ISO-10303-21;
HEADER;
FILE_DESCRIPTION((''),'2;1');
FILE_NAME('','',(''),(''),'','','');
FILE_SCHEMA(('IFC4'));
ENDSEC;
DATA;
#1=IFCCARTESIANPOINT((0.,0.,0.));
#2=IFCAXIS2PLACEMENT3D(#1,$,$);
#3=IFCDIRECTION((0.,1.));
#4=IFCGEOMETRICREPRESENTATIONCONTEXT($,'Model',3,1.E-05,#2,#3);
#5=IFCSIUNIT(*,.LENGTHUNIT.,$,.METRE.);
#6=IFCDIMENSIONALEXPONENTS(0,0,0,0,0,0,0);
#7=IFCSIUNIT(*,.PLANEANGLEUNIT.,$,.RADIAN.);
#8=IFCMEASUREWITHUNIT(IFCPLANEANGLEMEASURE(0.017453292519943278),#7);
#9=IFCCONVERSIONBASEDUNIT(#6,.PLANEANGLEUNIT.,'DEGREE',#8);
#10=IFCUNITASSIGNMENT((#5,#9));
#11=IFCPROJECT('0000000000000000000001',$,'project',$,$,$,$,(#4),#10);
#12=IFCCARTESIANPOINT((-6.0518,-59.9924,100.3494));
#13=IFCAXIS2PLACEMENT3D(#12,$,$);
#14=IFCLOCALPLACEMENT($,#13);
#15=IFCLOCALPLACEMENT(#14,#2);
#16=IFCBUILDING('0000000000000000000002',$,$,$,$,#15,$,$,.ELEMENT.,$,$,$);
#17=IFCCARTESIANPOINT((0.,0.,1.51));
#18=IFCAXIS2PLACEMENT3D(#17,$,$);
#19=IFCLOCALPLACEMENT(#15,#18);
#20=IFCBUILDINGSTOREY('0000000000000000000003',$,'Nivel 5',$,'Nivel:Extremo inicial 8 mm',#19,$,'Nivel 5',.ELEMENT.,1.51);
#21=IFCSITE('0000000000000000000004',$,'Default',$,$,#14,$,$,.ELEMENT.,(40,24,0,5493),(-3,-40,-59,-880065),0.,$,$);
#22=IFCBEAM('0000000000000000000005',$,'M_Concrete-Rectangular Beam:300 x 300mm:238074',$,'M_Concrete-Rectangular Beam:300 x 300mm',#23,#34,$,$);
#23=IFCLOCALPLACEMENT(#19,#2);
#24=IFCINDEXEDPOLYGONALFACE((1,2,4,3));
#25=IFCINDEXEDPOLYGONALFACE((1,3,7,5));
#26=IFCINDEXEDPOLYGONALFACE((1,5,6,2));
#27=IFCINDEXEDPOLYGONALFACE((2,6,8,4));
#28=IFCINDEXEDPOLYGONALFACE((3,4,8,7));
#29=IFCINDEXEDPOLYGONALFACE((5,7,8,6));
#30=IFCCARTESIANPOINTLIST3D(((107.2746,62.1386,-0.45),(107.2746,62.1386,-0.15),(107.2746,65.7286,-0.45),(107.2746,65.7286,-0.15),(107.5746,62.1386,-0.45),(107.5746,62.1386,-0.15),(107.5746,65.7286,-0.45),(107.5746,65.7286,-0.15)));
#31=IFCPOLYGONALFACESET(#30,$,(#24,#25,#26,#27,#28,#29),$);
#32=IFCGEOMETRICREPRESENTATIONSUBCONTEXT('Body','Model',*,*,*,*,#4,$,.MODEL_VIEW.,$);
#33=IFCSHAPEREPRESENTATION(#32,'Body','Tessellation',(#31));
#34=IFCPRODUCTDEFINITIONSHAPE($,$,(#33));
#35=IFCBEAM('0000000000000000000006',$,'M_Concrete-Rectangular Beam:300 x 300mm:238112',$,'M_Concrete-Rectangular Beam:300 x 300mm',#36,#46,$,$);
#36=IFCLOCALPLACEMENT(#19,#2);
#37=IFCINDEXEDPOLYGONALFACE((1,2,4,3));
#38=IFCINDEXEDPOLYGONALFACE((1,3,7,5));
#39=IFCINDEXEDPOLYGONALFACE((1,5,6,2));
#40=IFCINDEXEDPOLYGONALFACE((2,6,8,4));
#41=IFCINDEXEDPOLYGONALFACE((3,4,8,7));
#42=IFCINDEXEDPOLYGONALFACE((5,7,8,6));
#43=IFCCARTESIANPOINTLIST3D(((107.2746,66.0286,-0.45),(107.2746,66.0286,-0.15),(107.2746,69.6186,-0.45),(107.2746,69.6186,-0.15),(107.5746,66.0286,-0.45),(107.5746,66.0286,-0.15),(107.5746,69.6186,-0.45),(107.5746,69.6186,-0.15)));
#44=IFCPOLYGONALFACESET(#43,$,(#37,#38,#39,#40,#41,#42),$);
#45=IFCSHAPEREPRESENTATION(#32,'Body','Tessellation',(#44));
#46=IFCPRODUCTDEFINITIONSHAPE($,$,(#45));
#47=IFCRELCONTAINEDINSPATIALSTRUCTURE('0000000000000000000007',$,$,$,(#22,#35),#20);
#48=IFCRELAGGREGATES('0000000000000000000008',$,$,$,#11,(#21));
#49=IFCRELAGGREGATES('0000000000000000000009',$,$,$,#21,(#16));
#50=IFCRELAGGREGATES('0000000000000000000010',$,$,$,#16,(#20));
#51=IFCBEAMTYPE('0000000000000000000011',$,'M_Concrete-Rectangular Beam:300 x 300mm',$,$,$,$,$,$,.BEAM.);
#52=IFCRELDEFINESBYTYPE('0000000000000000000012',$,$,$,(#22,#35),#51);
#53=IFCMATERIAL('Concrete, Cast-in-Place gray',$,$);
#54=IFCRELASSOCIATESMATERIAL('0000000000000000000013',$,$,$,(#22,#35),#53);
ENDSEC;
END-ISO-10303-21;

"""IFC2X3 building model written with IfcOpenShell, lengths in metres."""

from ifc_helpers import new_model, entity, si_unit, converted_unit, direction, frame, origin, origin_2d_with_axis, place, context, subcontext, project, spatial, rectangle, extrude, material, type_object, element, save


model = new_model("IFC2X3")

# Units and contexts
model_context = context("Model", 3, precision=1e-05, world=origin(), true_north=direction((0.0, 1.0)))
body_context = subcontext(model_context, "Body", "Model", "MODEL_VIEW")
ifc_project = project(units=[si_unit("LENGTHUNIT", "METRE"), converted_unit("PLANEANGLEUNIT", "DEGREE", entity("IfcPlaneAngleMeasure", 0.017453292519943278), si_unit("PLANEANGLEUNIT", "RADIAN"), dimensions=[0, 0, 0, 0, 0, 0, 0])], contexts=[model_context])

# Site, building, storey
site_placement = place(None, frame((-6.0518, -59.9924, 100.3494)))
site = spatial("IfcSite", under=ifc_project, at=site_placement, Name="Default", CompositionType="ELEMENT", RefLatitude=(40, 24, 0, 5493), RefLongitude=(-3, -40, -59, -880065), RefElevation=0.0)
building_placement = place(site_placement, origin())
building = spatial("IfcBuilding", under=site, at=building_placement, CompositionType="ELEMENT")
storey_placement = place(building_placement, frame((0.0, 0.0, 1.51)))
storey = spatial("IfcBuildingStorey", under=building, at=storey_placement, Name="Nivel 5", ObjectType="Nivel:Extremo inicial 8 mm", LongName="Nivel 5", CompositionType="ELEMENT", Elevation=1.51)

# Beams
ifc_material_1 = material(Name="Concrete, Cast-in-Place gray")
beam_type = type_object("IfcBeamType", Name="M_Concrete-Rectangular Beam:300 x 300mm", PredefinedType="BEAM")
beam_1_placement = place(storey_placement, frame((107.4246, 61.9886, 0.0), z_axis=(0.0, 0.0, 1.0), x_axis=(0.0, 1.0, 0.0)))
element("IfcBeam", 1, at=beam_1_placement, inside=storey, type_object=beam_type, material=ifc_material_1, Name="M_Concrete-Rectangular Beam:300 x 300mm:238074", ObjectType="M_Concrete-Rectangular Beam:300 x 300mm", context=body_context, shape_type="SweptSolid", body=[
    extrude(rectangle(XDim=0.3, YDim=0.3, at=origin_2d_with_axis()), frame((0.15, 0.0, -0.3), z_axis=(1.0, 0.0, 0.0), x_axis=(0.0, 0.0, -1.0)), (0.0, 0.0, 1.0), 3.59),
])
beam_2_placement = place(storey_placement, frame((107.4246, 65.8786, 0.0), z_axis=(0.0, 0.0, 1.0), x_axis=(0.0, 1.0, 0.0)))
element("IfcBeam", 2, at=beam_2_placement, inside=storey, type_object=beam_type, material=ifc_material_1, Name="M_Concrete-Rectangular Beam:300 x 300mm:238112", ObjectType="M_Concrete-Rectangular Beam:300 x 300mm", context=body_context, shape_type="SweptSolid", body=[
    extrude(rectangle(XDim=0.3, YDim=0.3, at=origin_2d_with_axis()), frame((0.15, 0.0, -0.3), z_axis=(1.0, 0.0, 0.0), x_axis=(0.0, 0.0, -1.0)), (0.0, 0.0, 1.0), 3.59),
])

save(model, "model.ifc")
